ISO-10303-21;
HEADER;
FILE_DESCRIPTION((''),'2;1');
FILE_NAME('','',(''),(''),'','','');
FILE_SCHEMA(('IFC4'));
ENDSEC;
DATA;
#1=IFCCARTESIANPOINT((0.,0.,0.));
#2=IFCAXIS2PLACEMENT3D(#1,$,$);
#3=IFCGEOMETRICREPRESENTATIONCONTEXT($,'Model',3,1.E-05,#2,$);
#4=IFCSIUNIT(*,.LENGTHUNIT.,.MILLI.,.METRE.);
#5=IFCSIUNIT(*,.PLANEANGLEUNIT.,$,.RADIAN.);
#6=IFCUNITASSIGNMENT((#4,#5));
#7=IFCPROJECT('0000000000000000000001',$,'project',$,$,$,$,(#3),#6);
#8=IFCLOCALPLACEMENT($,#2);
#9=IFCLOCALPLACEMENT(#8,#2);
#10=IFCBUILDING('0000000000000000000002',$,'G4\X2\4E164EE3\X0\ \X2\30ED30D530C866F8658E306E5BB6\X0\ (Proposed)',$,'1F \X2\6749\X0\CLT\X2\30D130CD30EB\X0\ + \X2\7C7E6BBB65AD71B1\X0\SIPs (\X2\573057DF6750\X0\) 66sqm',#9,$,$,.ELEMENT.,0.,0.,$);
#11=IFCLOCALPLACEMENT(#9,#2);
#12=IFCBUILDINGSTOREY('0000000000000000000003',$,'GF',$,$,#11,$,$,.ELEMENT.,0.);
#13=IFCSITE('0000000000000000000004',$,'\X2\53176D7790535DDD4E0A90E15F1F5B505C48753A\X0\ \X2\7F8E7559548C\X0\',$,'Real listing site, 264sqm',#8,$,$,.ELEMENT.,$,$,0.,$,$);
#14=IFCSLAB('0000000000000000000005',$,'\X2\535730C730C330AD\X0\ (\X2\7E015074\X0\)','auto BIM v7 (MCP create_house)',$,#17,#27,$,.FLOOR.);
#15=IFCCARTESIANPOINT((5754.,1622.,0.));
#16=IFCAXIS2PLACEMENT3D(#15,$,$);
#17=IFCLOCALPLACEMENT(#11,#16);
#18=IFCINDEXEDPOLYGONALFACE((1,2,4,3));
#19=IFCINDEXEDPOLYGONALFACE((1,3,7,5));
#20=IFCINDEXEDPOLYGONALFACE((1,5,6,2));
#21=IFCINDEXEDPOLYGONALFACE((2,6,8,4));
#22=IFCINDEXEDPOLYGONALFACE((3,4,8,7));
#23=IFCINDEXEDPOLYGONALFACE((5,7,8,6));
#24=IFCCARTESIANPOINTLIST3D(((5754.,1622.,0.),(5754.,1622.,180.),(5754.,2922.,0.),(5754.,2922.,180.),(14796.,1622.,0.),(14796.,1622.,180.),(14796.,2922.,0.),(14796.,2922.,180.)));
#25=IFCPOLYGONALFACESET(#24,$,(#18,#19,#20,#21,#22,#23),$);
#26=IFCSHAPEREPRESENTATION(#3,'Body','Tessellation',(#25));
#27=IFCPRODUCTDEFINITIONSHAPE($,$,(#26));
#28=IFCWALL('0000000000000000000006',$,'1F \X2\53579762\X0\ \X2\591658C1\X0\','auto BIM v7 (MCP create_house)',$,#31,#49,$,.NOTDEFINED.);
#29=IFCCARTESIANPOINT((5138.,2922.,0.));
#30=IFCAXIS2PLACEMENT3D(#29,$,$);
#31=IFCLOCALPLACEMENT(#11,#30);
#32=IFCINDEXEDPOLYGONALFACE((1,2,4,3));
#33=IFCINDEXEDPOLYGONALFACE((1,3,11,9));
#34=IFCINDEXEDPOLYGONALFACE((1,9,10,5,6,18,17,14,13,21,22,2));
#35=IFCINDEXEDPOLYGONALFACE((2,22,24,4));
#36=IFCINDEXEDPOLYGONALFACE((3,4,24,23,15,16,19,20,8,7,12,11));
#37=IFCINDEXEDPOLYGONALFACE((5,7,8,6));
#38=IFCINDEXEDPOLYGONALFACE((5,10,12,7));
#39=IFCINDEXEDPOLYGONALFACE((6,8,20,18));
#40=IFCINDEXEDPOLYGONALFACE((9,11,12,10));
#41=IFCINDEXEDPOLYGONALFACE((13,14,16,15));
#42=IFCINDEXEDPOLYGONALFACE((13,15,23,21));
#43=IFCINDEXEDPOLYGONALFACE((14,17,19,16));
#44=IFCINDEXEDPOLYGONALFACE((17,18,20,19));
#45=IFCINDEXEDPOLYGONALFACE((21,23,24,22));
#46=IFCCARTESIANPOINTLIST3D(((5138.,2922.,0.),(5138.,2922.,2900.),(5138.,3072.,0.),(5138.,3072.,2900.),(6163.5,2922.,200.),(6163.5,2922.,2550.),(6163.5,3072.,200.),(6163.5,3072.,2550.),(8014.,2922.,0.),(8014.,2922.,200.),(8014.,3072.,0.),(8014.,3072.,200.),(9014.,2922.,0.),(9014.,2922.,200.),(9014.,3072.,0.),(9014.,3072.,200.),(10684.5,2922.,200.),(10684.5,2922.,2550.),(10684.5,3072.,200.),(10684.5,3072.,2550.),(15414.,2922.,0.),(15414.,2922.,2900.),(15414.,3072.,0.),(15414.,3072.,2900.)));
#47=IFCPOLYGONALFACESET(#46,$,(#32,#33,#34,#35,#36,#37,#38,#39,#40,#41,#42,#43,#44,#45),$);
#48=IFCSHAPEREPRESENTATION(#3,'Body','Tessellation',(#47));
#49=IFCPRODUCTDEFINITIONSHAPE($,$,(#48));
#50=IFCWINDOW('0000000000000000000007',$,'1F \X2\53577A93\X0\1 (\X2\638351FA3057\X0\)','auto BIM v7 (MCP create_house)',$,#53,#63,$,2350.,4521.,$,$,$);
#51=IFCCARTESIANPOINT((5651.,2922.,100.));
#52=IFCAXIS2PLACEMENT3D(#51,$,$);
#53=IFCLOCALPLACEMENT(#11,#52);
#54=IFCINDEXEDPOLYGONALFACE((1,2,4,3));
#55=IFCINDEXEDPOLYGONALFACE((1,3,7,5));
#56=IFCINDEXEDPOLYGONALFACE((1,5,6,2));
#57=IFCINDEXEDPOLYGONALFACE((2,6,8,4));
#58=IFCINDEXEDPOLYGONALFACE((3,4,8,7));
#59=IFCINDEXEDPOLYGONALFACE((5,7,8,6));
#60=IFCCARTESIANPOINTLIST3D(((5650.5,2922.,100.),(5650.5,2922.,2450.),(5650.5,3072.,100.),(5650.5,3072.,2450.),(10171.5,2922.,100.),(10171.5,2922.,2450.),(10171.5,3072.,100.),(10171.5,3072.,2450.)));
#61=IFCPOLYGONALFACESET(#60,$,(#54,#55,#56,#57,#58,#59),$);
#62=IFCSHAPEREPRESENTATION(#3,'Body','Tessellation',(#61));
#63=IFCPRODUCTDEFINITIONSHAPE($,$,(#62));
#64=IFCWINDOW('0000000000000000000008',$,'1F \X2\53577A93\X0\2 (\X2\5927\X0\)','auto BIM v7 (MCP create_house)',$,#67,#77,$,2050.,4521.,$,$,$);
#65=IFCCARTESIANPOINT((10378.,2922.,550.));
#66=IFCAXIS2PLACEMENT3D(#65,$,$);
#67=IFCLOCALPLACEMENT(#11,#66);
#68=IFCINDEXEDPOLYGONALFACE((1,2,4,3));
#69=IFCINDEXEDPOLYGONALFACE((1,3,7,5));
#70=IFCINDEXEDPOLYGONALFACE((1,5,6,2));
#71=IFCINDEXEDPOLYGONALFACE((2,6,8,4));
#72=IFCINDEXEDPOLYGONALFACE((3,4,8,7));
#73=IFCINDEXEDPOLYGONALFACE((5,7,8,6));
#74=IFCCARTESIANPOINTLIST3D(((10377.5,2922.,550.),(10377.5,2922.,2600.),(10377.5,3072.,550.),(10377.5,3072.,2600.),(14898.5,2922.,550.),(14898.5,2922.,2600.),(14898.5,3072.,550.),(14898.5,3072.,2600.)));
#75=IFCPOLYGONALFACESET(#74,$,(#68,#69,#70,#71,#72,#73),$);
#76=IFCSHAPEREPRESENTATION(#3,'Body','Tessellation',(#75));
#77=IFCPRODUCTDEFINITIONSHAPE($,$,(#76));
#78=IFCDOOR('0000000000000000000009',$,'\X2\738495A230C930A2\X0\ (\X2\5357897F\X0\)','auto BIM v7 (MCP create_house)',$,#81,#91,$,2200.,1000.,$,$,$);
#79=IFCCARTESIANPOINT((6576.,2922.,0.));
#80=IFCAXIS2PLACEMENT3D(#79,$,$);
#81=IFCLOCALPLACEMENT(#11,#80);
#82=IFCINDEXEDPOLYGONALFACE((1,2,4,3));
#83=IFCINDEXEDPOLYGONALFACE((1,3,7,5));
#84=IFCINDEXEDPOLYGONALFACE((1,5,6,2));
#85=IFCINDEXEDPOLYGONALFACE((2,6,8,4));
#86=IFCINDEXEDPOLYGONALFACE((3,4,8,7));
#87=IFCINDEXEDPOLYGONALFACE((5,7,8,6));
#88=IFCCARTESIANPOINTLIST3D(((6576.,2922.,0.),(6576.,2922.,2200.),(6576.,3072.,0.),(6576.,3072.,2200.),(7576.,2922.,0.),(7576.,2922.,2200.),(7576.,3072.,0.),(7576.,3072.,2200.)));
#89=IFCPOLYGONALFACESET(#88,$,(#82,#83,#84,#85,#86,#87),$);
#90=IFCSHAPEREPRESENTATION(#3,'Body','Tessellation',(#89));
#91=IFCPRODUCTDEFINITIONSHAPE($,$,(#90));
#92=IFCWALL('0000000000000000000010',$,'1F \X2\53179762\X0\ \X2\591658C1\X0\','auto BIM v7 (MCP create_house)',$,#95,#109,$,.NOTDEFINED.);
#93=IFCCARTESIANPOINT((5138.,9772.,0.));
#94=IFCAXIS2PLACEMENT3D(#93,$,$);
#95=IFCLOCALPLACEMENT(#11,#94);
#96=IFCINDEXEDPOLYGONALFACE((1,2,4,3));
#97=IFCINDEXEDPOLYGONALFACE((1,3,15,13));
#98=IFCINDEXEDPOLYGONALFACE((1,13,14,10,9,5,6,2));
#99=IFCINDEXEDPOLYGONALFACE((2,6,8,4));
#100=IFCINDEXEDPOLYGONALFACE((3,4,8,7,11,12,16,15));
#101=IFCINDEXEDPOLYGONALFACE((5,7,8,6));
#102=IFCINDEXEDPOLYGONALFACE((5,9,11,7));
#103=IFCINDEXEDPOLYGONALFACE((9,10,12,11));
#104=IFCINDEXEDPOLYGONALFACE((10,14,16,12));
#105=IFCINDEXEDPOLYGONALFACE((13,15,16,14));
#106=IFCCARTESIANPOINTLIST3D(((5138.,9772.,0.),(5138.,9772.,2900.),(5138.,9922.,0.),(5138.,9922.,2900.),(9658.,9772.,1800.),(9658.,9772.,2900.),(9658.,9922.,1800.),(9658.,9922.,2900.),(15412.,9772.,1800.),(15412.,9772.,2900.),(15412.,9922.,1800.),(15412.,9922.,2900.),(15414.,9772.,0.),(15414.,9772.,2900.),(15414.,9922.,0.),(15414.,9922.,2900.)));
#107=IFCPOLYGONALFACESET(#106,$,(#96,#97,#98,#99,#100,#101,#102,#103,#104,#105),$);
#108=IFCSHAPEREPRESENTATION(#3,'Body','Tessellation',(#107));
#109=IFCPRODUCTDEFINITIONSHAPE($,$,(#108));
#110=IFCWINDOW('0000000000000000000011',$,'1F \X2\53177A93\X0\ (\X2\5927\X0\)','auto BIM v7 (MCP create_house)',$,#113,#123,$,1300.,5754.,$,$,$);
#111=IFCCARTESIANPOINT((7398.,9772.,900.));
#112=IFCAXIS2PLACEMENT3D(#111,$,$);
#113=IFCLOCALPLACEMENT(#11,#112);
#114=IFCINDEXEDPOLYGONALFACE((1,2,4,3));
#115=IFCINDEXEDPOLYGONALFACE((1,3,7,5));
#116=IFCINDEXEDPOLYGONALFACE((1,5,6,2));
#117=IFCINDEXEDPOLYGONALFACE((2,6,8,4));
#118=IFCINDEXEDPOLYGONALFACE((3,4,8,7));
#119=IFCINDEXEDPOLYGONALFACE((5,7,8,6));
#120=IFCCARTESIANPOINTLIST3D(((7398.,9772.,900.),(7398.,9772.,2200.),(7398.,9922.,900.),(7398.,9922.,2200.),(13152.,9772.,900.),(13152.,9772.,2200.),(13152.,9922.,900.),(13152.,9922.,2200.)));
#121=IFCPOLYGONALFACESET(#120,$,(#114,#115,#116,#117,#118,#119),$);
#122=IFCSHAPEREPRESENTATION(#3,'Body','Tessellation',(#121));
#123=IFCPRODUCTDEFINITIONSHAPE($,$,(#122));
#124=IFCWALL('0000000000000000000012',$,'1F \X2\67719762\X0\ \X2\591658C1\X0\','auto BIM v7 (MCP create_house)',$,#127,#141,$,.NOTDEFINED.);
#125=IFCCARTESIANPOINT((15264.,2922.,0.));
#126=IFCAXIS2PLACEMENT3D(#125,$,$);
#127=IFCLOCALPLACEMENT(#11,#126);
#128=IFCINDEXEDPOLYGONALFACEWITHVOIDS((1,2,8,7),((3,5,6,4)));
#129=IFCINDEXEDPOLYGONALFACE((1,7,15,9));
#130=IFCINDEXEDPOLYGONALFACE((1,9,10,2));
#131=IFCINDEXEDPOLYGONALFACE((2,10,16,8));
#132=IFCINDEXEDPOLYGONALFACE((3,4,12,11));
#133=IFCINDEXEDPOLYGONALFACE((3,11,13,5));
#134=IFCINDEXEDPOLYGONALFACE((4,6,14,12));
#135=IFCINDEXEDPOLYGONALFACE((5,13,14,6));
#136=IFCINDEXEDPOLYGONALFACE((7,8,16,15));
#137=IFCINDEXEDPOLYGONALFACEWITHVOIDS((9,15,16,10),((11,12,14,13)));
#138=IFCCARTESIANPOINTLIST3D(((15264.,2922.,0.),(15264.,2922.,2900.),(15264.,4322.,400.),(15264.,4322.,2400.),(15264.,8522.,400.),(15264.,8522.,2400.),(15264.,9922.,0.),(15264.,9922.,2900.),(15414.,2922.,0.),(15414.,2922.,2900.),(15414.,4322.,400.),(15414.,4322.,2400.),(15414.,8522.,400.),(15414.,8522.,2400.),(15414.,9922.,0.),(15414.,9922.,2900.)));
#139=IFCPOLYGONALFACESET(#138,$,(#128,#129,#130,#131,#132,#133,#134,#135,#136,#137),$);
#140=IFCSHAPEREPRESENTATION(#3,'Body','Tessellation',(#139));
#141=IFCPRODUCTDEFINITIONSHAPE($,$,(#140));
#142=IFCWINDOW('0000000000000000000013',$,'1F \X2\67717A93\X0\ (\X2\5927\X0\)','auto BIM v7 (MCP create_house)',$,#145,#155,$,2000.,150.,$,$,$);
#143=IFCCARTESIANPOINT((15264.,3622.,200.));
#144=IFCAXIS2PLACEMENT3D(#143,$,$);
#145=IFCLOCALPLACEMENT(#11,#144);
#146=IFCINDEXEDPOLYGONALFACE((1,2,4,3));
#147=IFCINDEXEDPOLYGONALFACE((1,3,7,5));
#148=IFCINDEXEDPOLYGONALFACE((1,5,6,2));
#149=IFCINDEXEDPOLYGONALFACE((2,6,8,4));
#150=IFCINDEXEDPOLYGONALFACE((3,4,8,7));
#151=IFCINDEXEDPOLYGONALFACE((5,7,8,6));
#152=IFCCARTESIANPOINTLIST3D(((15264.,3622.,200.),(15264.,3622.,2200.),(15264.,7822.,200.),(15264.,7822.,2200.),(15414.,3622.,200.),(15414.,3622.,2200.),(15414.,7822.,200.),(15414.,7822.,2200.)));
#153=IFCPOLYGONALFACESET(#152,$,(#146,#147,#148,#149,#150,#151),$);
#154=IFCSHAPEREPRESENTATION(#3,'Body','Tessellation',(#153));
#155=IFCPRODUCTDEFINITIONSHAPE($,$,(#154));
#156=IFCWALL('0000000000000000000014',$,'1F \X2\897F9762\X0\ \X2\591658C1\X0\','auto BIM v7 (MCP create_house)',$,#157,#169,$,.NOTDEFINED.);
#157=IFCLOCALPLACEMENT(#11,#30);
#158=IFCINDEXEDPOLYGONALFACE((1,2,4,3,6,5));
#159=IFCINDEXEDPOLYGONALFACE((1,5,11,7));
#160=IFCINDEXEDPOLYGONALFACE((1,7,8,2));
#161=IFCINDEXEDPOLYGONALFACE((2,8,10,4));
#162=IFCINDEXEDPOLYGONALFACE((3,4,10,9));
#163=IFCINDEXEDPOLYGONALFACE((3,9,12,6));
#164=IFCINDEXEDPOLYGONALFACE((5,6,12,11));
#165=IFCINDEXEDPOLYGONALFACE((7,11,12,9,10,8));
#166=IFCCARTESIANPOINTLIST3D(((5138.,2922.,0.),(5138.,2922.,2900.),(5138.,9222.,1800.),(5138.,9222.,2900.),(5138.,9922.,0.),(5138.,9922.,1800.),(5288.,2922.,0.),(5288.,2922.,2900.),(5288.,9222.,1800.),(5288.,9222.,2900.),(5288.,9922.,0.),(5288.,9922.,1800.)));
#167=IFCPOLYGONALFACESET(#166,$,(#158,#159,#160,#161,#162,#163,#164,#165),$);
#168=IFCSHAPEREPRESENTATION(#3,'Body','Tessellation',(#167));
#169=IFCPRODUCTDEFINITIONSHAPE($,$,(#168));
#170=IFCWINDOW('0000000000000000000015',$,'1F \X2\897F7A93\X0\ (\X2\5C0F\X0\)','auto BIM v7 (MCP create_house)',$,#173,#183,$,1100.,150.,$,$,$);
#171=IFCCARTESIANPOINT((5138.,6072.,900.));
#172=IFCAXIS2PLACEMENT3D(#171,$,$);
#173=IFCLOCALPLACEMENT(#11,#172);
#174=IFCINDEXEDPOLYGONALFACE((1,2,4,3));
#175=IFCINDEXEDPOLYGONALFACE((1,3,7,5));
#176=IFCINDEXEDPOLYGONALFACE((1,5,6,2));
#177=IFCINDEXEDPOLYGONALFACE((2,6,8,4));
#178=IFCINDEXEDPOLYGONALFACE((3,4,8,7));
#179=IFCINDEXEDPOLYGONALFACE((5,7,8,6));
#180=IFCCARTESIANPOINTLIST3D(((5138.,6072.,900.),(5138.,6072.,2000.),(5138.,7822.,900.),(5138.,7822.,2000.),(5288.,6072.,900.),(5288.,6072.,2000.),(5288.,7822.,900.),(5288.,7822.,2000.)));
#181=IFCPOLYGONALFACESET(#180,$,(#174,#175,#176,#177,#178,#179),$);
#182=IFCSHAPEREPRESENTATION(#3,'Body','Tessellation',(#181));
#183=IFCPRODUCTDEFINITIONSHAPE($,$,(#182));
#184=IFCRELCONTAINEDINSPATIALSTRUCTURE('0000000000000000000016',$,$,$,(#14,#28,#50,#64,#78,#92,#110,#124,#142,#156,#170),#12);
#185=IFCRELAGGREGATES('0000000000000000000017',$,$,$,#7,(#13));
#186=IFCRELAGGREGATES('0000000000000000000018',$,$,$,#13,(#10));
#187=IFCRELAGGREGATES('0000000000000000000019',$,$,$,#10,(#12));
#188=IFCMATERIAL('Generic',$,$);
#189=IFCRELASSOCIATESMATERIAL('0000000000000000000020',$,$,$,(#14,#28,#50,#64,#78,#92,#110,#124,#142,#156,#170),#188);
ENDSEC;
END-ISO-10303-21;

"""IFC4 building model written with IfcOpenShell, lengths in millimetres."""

from ifc_helpers import new_model, si_unit, frame, frame_2d, origin, place, context, project, spatial, rectangle, extrude, material, element, fill, save


model = new_model("IFC4")

# Units and contexts
model_context = context("Model", 3, precision=1e-05, world=origin())
ifc_project = project(units=[si_unit("LENGTHUNIT", "METRE", prefix="MILLI"), si_unit("PLANEANGLEUNIT", "RADIAN")], contexts=[model_context])

# Site, building, storey
site_placement = place(None, origin())
site = spatial("IfcSite", under=ifc_project, at=site_placement, Name="北海道川上郡弟子屈町 美留和", ObjectType="Real listing site, 264sqm", CompositionType="ELEMENT", RefElevation=0.0)
building_placement = place(site_placement, origin())
building = spatial("IfcBuilding", under=site, at=building_placement, Name="G4世代 ロフト書斎の家 (Proposed)", ObjectType="1F 杉CLTパネル + 籾殻断熱SIPs (地域材) 66sqm", CompositionType="ELEMENT", ElevationOfRefHeight=0.0, ElevationOfTerrain=0.0)
storey_placement = place(building_placement, origin())
storey = spatial("IfcBuildingStorey", under=building, at=storey_placement, Name="GF", CompositionType="ELEMENT", Elevation=0.0)

# Slab
ifc_material = material(Name="Generic")
slab_1_placement = place(storey_placement, frame((5754.0, 1622.0, 0.0)))
element("IfcSlab", 1, at=slab_1_placement, inside=storey, material=ifc_material, Name="南デッキ (縁側)", Description="auto BIM v7 (MCP create_house)", PredefinedType="FLOOR", context=model_context, shape_type="SweptSolid", body=[
    extrude(rectangle(XDim=9042.0, YDim=1300.0, at=frame_2d((4521.0, 650.0))), frame((5754.0, 1622.0, 0.0)), (0.0, 0.0, 1.0), 180.0),
])

# Wall, openings, windows, door
wall_1_placement = place(storey_placement, frame((5138.0, 2922.0, 0.0)))
wall_1 = element("IfcWall", 2, at=wall_1_placement, inside=storey, material=ifc_material, Name="1F 南面 外壁", Description="auto BIM v7 (MCP create_house)", PredefinedType="NOTDEFINED", context=model_context, shape_type="SweptSolid", body=[
    extrude(rectangle(XDim=10276.0, YDim=150.0, at=frame_2d((5138.0, 75.0))), frame((5138.0, 2922.0, 0.0)), (0.0, 0.0, 1.0), 2900.0),
])
opening_1_placement = place(storey_placement, frame((5651.0, 2922.0, 100.0)))
opening_1 = element("IfcOpeningElement", 3, at=opening_1_placement, cuts=wall_1, PredefinedType="NOTDEFINED", context=model_context, shape_type="SweptSolid", body=[
    extrude(rectangle(XDim=4521.0, YDim=150.0, at=frame_2d((2260.0, 75.0))), frame((5651.0, 2922.0, 100.0)), (0.0, 0.0, 1.0), 2350.0),
])
opening_2_placement = place(storey_placement, frame((10378.0, 2922.0, 550.0)))
opening_2 = element("IfcOpeningElement", 4, at=opening_2_placement, cuts=wall_1, PredefinedType="NOTDEFINED", context=model_context, shape_type="SweptSolid", body=[
    extrude(rectangle(XDim=4521.0, YDim=150.0, at=frame_2d((2260.0, 75.0))), frame((10378.0, 2922.0, 550.0)), (0.0, 0.0, 1.0), 2050.0),
])
opening_3_placement = place(storey_placement, frame((6576.0, 2922.0, 0.0)))
opening_3 = element("IfcOpeningElement", 5, at=opening_3_placement, cuts=wall_1, PredefinedType="NOTDEFINED", context=model_context, shape_type="SweptSolid", body=[
    extrude(rectangle(XDim=1000.0, YDim=150.0, at=frame_2d((500.0, 75.0))), frame((6576.0, 2922.0, 0.0)), (0.0, 0.0, 1.0), 2200.0),
])
window_1_placement = place(storey_placement, frame((5651.0, 2922.0, 100.0)))
window_1 = element("IfcWindow", 6, at=window_1_placement, inside=storey, material=ifc_material, Name="1F 南窓1 (掃出し)", Description="auto BIM v7 (MCP create_house)", OverallHeight=2350.0, OverallWidth=4521.0, context=model_context, shape_type="SweptSolid", body=[
    extrude(rectangle(XDim=4521.0, YDim=150.0, at=frame_2d((2260.0, 75.0))), frame((5651.0, 2922.0, 100.0)), (0.0, 0.0, 1.0), 2350.0),
])
fill(opening_1, window_1)
window_2_placement = place(storey_placement, frame((10378.0, 2922.0, 550.0)))
window_2 = element("IfcWindow", 7, at=window_2_placement, inside=storey, material=ifc_material, Name="1F 南窓2 (大)", Description="auto BIM v7 (MCP create_house)", OverallHeight=2050.0, OverallWidth=4521.0, context=model_context, shape_type="SweptSolid", body=[
    extrude(rectangle(XDim=4521.0, YDim=150.0, at=frame_2d((2260.0, 75.0))), frame((10378.0, 2922.0, 550.0)), (0.0, 0.0, 1.0), 2050.0),
])
fill(opening_2, window_2)
door_placement = place(storey_placement, frame((6576.0, 2922.0, 0.0)))
door = element("IfcDoor", 8, at=door_placement, inside=storey, material=ifc_material, Name="玄関ドア (南西)", Description="auto BIM v7 (MCP create_house)", OverallHeight=2200.0, OverallWidth=1000.0, context=model_context, shape_type="SweptSolid", body=[
    extrude(rectangle(XDim=1000.0, YDim=150.0, at=frame_2d((500.0, 75.0))), frame((6576.0, 2922.0, 0.0)), (0.0, 0.0, 1.0), 2200.0),
])
fill(opening_3, door)

# Walls, openings, windows
wall_2_placement = place(storey_placement, frame((5138.0, 9772.0, 0.0)))
wall_2 = element("IfcWall", 9, at=wall_2_placement, inside=storey, material=ifc_material, Name="1F 北面 外壁", Description="auto BIM v7 (MCP create_house)", PredefinedType="NOTDEFINED", context=model_context, shape_type="SweptSolid", body=[
    extrude(rectangle(XDim=10276.0, YDim=150.0, at=frame_2d((5138.0, 75.0))), frame((5138.0, 9772.0, 0.0)), (0.0, 0.0, 1.0), 2900.0),
])
opening_4_placement = place(storey_placement, frame((7398.0, 9772.0, 900.0)))
opening_4 = element("IfcOpeningElement", 10, at=opening_4_placement, cuts=wall_2, PredefinedType="NOTDEFINED", context=model_context, shape_type="SweptSolid", body=[
    extrude(rectangle(XDim=5754.0, YDim=150.0, at=frame_2d((2877.0, 75.0))), frame((7398.0, 9772.0, 900.0)), (0.0, 0.0, 1.0), 1300.0),
])
window_3_placement = place(storey_placement, frame((7398.0, 9772.0, 900.0)))
window_3 = element("IfcWindow", 11, at=window_3_placement, inside=storey, material=ifc_material, Name="1F 北窓 (大)", Description="auto BIM v7 (MCP create_house)", OverallHeight=1300.0, OverallWidth=5754.0, context=model_context, shape_type="SweptSolid", body=[
    extrude(rectangle(XDim=5754.0, YDim=150.0, at=frame_2d((2877.0, 75.0))), frame((7398.0, 9772.0, 900.0)), (0.0, 0.0, 1.0), 1300.0),
])
fill(opening_4, window_3)
wall_3_placement = place(storey_placement, frame((15264.0, 2922.0, 0.0)))
wall_3 = element("IfcWall", 12, at=wall_3_placement, inside=storey, material=ifc_material, Name="1F 東面 外壁", Description="auto BIM v7 (MCP create_house)", PredefinedType="NOTDEFINED", context=model_context, shape_type="SweptSolid", body=[
    extrude(rectangle(XDim=150.0, YDim=7000.0, at=frame_2d((75.0, 3500.0))), frame((15264.0, 2922.0, 0.0)), (0.0, 0.0, 1.0), 2900.0),
])
opening_5_placement = place(storey_placement, frame((15264.0, 3622.0, 200.0)))
opening_5 = element("IfcOpeningElement", 13, at=opening_5_placement, cuts=wall_3, PredefinedType="NOTDEFINED", context=model_context, shape_type="SweptSolid", body=[
    extrude(rectangle(XDim=150.0, YDim=4200.0, at=frame_2d((75.0, 2100.0))), frame((15264.0, 3622.0, 200.0)), (0.0, 0.0, 1.0), 2000.0),
])
window_4_placement = place(storey_placement, frame((15264.0, 3622.0, 200.0)))
window_4 = element("IfcWindow", 14, at=window_4_placement, inside=storey, material=ifc_material, Name="1F 東窓 (大)", Description="auto BIM v7 (MCP create_house)", OverallHeight=2000.0, OverallWidth=150.0, context=model_context, shape_type="SweptSolid", body=[
    extrude(rectangle(XDim=150.0, YDim=4200.0, at=frame_2d((75.0, 2100.0))), frame((15264.0, 3622.0, 200.0)), (0.0, 0.0, 1.0), 2000.0),
])
fill(opening_5, window_4)
wall_4_placement = place(storey_placement, frame((5138.0, 2922.0, 0.0)))
wall_4 = element("IfcWall", 15, at=wall_4_placement, inside=storey, material=ifc_material, Name="1F 西面 外壁", Description="auto BIM v7 (MCP create_house)", PredefinedType="NOTDEFINED", context=model_context, shape_type="SweptSolid", body=[
    extrude(rectangle(XDim=150.0, YDim=7000.0, at=frame_2d((75.0, 3500.0))), frame((5138.0, 2922.0, 0.0)), (0.0, 0.0, 1.0), 2900.0),
])
opening_6_placement = place(storey_placement, frame((5138.0, 6072.0, 900.0)))
opening_6 = element("IfcOpeningElement", 16, at=opening_6_placement, cuts=wall_4, PredefinedType="NOTDEFINED", context=model_context, shape_type="SweptSolid", body=[
    extrude(rectangle(XDim=150.0, YDim=1750.0, at=frame_2d((75.0, 875.0))), frame((5138.0, 6072.0, 900.0)), (0.0, 0.0, 1.0), 1100.0),
])
window_5_placement = place(storey_placement, frame((5138.0, 6072.0, 900.0)))
window_5 = element("IfcWindow", 17, at=window_5_placement, inside=storey, material=ifc_material, Name="1F 西窓 (小)", Description="auto BIM v7 (MCP create_house)", OverallHeight=1100.0, OverallWidth=150.0, context=model_context, shape_type="SweptSolid", body=[
    extrude(rectangle(XDim=150.0, YDim=1750.0, at=frame_2d((75.0, 875.0))), frame((5138.0, 6072.0, 900.0)), (0.0, 0.0, 1.0), 1100.0),
])
fill(opening_6, window_5)

save(model, "model.ifc")
